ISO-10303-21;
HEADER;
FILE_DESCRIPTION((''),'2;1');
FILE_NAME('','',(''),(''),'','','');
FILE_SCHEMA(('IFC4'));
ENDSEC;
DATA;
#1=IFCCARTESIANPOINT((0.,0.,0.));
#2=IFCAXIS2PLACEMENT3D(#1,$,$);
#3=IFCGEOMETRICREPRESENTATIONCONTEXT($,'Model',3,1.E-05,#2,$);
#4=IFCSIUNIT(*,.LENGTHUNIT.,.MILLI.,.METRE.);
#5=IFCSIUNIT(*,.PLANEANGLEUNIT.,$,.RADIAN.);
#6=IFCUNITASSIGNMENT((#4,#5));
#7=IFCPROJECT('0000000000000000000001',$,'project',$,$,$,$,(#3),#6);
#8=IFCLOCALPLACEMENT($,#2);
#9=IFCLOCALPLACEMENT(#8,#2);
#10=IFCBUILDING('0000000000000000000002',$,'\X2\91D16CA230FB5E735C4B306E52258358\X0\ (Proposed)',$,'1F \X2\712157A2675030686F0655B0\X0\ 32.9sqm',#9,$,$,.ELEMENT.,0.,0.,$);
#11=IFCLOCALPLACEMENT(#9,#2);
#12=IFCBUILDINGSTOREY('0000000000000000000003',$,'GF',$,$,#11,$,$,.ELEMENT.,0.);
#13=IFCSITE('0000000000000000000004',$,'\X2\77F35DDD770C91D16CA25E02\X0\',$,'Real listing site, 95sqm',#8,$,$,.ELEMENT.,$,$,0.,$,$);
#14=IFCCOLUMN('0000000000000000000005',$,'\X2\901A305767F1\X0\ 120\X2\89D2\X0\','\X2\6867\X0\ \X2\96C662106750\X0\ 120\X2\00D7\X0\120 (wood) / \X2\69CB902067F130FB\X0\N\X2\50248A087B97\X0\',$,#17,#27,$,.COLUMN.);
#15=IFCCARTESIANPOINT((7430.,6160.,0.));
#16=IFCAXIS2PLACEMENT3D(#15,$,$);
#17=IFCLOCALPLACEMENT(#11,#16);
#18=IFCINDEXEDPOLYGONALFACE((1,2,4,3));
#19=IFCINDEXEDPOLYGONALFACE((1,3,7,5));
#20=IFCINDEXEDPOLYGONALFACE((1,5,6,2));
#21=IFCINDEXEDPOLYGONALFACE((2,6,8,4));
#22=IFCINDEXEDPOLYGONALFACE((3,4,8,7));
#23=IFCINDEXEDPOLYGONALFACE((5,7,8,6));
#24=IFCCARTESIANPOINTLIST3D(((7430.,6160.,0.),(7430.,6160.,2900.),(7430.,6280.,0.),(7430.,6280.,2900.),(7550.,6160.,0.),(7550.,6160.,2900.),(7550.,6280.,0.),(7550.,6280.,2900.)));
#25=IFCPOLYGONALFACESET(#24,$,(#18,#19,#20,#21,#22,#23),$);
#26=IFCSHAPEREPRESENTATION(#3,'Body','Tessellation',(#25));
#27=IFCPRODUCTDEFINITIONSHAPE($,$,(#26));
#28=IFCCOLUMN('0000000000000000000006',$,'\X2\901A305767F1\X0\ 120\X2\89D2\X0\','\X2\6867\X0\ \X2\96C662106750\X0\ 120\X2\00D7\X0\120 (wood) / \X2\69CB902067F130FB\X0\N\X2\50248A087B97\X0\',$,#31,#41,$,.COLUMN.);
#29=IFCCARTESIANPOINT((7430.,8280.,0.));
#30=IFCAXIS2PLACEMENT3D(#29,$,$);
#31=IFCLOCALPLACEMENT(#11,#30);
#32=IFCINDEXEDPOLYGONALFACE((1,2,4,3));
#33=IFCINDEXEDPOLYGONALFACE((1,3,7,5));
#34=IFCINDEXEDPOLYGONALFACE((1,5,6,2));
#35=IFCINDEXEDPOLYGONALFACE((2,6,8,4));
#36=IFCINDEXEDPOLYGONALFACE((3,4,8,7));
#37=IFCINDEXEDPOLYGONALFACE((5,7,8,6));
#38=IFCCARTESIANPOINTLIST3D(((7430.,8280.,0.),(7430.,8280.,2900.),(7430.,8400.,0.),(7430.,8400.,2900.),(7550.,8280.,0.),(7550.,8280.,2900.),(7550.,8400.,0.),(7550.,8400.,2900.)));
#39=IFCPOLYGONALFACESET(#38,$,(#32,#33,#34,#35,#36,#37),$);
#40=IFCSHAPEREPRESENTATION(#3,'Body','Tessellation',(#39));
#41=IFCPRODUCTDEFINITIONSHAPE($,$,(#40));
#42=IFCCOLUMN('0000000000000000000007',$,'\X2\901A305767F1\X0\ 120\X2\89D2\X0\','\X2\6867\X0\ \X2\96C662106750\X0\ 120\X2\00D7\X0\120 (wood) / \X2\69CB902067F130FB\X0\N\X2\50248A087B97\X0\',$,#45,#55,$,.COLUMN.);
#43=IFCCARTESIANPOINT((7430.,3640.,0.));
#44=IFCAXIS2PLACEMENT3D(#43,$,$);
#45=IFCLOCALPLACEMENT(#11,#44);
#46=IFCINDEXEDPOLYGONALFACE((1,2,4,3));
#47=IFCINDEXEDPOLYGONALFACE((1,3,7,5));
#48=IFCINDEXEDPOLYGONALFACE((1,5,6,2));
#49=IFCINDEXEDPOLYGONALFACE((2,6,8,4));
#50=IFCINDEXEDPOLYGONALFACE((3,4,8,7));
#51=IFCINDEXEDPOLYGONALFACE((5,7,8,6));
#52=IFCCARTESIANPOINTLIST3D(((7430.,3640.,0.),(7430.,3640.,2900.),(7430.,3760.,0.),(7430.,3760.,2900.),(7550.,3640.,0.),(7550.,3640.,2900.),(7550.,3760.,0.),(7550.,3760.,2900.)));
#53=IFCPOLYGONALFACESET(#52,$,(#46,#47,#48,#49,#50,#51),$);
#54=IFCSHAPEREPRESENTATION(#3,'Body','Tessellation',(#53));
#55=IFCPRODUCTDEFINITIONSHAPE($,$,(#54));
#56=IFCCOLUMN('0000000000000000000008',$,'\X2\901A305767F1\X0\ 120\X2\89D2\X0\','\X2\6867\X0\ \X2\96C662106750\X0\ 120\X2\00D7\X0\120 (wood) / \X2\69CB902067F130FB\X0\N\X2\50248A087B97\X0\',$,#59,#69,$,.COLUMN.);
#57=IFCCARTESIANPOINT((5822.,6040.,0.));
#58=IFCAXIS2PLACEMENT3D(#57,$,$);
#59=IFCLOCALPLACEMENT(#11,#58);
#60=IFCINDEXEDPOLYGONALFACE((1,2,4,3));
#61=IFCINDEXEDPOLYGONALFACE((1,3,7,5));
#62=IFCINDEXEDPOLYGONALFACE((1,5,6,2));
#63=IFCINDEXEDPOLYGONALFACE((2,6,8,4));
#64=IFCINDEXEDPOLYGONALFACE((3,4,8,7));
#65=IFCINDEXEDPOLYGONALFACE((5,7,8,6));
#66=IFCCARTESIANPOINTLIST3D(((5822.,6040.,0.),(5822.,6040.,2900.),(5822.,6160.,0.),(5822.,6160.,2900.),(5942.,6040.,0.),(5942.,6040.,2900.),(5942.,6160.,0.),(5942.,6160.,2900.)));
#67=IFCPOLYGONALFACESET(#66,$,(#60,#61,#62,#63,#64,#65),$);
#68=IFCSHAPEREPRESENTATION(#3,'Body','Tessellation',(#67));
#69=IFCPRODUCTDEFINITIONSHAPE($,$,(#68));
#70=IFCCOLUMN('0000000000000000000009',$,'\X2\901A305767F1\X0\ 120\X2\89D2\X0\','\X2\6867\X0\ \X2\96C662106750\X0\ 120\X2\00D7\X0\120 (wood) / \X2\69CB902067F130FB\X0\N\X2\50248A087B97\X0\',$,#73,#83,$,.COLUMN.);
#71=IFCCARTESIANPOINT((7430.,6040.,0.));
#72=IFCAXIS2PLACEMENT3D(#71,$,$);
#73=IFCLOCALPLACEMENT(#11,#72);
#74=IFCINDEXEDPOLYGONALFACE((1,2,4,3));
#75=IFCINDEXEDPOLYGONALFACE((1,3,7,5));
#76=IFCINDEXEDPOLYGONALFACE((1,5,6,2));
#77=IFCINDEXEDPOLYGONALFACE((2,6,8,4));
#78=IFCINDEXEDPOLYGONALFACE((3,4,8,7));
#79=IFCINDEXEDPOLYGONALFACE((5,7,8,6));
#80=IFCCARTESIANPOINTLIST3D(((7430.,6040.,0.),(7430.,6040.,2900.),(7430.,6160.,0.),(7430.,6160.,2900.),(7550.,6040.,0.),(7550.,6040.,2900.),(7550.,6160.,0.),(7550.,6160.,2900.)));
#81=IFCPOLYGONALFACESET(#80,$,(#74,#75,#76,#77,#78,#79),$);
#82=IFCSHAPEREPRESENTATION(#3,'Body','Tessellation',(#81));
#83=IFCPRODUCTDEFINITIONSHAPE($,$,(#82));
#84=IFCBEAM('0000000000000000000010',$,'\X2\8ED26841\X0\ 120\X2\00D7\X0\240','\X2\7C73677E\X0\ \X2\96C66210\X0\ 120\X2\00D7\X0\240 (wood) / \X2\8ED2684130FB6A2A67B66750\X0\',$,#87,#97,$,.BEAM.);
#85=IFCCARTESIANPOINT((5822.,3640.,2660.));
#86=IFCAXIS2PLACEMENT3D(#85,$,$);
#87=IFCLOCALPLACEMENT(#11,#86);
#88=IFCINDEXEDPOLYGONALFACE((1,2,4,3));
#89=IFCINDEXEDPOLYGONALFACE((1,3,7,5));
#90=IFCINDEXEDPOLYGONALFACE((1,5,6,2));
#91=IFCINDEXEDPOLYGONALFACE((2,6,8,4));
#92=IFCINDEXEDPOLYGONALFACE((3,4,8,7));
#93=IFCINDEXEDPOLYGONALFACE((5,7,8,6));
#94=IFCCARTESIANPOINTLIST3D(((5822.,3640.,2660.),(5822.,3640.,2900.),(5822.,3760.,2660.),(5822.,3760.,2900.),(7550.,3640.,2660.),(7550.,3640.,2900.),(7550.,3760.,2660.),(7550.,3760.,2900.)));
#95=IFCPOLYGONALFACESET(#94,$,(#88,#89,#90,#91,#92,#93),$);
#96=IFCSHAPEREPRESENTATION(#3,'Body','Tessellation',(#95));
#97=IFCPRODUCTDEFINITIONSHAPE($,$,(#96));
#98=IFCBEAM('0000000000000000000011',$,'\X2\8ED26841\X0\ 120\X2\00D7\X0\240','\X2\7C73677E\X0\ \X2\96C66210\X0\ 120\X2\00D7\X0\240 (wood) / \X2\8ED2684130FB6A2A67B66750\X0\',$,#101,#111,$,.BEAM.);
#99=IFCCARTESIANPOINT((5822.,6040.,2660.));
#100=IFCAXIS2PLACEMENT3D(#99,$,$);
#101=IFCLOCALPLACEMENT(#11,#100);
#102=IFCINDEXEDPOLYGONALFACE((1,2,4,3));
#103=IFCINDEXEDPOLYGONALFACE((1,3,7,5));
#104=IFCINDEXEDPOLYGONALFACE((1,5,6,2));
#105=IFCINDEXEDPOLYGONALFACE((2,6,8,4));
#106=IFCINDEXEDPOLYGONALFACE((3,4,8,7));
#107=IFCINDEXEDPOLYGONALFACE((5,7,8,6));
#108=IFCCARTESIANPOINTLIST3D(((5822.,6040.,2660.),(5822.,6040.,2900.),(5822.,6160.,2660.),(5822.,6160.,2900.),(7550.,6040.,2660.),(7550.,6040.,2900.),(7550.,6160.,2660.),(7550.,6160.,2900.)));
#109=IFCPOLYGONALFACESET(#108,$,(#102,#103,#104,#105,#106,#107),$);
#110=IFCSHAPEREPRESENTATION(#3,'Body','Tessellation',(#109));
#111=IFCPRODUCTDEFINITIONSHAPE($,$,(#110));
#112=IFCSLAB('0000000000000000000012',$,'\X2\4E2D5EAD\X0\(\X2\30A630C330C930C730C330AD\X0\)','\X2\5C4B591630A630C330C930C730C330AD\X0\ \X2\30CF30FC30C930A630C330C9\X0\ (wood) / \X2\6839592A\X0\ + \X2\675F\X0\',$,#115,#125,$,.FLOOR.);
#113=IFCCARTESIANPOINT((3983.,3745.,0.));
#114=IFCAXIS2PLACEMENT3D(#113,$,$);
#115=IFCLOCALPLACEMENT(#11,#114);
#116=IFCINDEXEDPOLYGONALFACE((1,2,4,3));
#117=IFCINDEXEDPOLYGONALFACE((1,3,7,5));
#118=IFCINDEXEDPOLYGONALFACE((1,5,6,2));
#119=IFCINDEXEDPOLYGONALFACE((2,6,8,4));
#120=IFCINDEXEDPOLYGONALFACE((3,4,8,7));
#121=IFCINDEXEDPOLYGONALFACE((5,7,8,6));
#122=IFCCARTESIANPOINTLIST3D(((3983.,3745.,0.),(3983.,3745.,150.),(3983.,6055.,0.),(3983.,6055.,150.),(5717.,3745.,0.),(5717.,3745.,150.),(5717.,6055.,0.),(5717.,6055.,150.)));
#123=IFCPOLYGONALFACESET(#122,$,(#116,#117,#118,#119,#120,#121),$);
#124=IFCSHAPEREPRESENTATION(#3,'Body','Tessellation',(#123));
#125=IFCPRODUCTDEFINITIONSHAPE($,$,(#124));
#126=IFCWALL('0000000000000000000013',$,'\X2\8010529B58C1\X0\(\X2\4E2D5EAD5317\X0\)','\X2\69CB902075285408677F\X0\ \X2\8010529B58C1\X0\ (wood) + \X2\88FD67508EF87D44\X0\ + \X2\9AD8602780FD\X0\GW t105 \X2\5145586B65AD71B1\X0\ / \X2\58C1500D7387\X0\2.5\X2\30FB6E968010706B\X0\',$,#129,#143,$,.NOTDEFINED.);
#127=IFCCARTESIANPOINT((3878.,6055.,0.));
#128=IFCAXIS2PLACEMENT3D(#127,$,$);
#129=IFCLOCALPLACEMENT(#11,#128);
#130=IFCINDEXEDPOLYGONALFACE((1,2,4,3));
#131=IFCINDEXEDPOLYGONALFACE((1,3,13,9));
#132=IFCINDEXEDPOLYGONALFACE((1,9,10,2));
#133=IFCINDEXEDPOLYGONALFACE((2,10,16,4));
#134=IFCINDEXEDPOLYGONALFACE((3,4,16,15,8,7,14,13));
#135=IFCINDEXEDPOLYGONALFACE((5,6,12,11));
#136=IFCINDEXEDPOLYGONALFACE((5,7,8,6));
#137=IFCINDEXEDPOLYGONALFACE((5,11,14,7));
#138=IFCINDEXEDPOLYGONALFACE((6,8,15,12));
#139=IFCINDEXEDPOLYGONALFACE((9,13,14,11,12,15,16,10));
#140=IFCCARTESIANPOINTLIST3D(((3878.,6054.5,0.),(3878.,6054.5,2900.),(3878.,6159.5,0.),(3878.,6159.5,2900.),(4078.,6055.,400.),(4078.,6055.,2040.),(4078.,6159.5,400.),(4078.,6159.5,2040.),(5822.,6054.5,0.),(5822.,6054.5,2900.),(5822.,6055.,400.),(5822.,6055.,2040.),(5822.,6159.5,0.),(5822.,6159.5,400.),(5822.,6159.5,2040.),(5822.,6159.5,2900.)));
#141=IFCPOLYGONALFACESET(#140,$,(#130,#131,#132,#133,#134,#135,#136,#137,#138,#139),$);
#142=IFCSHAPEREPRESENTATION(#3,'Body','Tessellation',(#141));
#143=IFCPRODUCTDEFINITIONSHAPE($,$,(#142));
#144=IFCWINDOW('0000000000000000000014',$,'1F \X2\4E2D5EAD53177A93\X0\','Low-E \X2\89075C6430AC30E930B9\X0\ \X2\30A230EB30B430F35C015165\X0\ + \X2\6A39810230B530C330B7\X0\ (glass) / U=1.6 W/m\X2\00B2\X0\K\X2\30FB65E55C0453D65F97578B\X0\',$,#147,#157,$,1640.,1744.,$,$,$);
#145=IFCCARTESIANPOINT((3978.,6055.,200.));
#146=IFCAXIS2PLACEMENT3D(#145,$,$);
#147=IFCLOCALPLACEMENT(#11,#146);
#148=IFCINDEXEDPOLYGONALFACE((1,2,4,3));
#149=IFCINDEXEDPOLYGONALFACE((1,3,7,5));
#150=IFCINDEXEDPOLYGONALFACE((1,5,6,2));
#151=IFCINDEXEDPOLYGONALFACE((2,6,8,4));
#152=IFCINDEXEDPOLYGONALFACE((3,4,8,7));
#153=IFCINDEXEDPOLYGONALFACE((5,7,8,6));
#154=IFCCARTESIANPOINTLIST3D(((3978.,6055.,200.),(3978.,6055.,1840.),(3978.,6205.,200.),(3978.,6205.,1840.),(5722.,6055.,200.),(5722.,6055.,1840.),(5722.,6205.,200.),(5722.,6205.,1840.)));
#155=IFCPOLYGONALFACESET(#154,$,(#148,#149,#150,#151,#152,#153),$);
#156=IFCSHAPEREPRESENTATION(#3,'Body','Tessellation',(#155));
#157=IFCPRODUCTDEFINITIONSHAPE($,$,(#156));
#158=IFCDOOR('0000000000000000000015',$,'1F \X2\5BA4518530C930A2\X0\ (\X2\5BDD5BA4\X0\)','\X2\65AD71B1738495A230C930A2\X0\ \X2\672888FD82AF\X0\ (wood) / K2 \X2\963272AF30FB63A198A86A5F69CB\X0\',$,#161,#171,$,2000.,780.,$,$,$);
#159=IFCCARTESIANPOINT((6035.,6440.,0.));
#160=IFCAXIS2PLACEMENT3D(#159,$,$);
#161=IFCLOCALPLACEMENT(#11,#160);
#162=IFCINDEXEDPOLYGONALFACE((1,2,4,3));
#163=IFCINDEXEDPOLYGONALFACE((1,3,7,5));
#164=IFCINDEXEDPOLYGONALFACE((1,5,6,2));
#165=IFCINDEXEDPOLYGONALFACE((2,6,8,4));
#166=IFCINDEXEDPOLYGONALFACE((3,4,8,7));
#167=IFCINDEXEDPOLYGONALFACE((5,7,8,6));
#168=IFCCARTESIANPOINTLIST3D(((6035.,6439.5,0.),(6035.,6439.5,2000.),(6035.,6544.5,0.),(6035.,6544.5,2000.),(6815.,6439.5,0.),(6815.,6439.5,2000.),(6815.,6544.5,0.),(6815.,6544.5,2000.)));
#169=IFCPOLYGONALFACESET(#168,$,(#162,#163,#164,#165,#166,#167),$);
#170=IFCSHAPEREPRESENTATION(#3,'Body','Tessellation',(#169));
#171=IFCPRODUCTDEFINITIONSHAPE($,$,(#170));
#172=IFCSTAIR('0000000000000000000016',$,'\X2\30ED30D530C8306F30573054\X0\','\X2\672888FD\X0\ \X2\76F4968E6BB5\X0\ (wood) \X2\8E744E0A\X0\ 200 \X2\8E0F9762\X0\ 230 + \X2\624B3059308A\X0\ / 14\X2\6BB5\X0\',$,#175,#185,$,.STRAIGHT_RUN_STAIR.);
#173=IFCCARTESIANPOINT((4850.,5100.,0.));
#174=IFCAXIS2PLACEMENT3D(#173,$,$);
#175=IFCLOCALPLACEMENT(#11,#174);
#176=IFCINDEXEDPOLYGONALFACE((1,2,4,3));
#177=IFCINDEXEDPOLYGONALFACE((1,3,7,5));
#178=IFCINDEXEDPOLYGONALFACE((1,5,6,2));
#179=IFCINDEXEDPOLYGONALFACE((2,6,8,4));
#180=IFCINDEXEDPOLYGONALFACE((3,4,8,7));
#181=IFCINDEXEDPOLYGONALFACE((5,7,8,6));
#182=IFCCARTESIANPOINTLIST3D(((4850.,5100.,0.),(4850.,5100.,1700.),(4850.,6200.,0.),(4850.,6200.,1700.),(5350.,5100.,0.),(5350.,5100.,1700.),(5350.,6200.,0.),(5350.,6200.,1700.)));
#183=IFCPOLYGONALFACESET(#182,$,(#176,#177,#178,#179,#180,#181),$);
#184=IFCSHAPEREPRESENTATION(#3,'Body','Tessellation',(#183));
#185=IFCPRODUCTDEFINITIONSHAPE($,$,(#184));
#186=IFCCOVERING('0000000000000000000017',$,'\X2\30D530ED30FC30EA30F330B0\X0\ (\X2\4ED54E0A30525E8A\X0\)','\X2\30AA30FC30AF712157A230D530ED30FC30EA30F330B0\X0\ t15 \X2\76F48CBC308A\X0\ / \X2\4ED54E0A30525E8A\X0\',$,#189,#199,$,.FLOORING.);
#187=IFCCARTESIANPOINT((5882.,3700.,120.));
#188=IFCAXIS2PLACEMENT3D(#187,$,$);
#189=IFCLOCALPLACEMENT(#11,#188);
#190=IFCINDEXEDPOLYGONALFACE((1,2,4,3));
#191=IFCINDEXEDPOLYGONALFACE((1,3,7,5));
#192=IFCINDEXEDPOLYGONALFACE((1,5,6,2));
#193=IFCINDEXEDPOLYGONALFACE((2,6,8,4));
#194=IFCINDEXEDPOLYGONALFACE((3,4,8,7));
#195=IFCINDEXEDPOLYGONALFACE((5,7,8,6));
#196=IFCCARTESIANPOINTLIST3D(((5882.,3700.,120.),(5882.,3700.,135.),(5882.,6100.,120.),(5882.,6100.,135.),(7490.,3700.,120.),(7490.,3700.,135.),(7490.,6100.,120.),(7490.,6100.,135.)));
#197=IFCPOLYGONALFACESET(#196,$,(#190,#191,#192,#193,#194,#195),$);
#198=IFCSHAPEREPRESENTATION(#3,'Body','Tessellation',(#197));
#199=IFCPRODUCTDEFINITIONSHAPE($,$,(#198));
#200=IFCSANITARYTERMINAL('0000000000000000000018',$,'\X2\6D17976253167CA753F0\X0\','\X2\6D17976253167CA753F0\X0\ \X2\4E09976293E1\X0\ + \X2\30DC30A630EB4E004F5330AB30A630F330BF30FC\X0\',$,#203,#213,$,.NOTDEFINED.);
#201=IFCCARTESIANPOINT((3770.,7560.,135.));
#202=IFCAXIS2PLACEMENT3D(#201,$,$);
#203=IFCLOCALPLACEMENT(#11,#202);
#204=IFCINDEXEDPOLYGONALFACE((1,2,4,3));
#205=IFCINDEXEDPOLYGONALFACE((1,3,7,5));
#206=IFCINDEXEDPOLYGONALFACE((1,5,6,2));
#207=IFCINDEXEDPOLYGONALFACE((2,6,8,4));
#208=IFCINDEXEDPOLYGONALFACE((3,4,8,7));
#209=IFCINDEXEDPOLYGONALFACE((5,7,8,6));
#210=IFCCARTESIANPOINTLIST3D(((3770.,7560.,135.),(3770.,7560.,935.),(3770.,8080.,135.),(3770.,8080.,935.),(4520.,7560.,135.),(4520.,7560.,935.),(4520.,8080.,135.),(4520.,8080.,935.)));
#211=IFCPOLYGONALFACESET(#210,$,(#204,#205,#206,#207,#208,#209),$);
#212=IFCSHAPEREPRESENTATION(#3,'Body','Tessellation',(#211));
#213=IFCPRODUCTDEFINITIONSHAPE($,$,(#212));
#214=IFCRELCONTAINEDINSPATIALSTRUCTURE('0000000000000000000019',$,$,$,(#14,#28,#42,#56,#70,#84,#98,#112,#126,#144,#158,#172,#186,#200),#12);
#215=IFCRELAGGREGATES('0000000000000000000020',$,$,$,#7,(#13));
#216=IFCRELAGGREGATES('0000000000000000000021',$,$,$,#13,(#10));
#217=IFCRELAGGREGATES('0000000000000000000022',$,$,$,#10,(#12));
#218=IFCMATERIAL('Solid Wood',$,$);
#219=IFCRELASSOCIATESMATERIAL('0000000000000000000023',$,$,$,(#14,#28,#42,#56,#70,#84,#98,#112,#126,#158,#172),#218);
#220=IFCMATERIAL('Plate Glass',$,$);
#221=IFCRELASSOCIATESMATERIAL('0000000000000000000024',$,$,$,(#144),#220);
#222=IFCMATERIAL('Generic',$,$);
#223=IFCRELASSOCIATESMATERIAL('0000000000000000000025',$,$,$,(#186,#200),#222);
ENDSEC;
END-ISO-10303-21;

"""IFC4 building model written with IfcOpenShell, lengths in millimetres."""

from ifc_helpers import new_model, si_unit, frame, frame_2d, origin, place, context, project, spatial, rectangle, extrude, material, element, fill, save


model = new_model("IFC4")

# Units and contexts
model_context = context("Model", 3, precision=1e-05, world=origin())
ifc_project = project(units=[si_unit("LENGTHUNIT", "METRE", prefix="MILLI"), si_unit("PLANEANGLEUNIT", "RADIAN")], contexts=[model_context])

# Site, building, storey
site_placement = place(None, origin())
site = spatial("IfcSite", under=ifc_project, at=site_placement, Name="石川県金沢市", ObjectType="Real listing site, 95sqm", CompositionType="ELEMENT", RefElevation=0.0)
building_placement = place(site_placement, origin())
building = spatial("IfcBuilding", under=site, at=building_placement, Name="金沢・平屋の別荘 (Proposed)", ObjectType="1F 無垢材と漆喰 32.9sqm", CompositionType="ELEMENT", ElevationOfRefHeight=0.0, ElevationOfTerrain=0.0)
storey_placement = place(building_placement, origin())
storey = spatial("IfcBuildingStorey", under=building, at=storey_placement, Name="GF", CompositionType="ELEMENT", Elevation=0.0)

# Columns
ifc_material_1 = material(Name="Solid Wood")
column_1_placement = place(storey_placement, frame((7430.0, 6160.0, 0.0)))
element("IfcColumn", 1, at=column_1_placement, inside=storey, material=ifc_material_1, Name="通し柱 120角", Description="桧 集成材 120×120 (wood) / 構造柱・N値計算", PredefinedType="COLUMN", context=model_context, shape_type="SweptSolid", body=[
    extrude(rectangle(XDim=120.0, YDim=120.0, at=frame_2d((60.0, 60.0))), frame((7430.0, 6160.0, 0.0)), (0.0, 0.0, 1.0), 2900.0),
])
column_2_placement = place(storey_placement, frame((7430.0, 8280.0, 0.0)))
element("IfcColumn", 2, at=column_2_placement, inside=storey, material=ifc_material_1, Name="通し柱 120角", Description="桧 集成材 120×120 (wood) / 構造柱・N値計算", PredefinedType="COLUMN", context=model_context, shape_type="SweptSolid", body=[
    extrude(rectangle(XDim=120.0, YDim=120.0, at=frame_2d((60.0, 60.0))), frame((7430.0, 8280.0, 0.0)), (0.0, 0.0, 1.0), 2900.0),
])
column_3_placement = place(storey_placement, frame((7430.0, 3640.0, 0.0)))
element("IfcColumn", 3, at=column_3_placement, inside=storey, material=ifc_material_1, Name="通し柱 120角", Description="桧 集成材 120×120 (wood) / 構造柱・N値計算", PredefinedType="COLUMN", context=model_context, shape_type="SweptSolid", body=[
    extrude(rectangle(XDim=120.0, YDim=120.0, at=frame_2d((60.0, 60.0))), frame((7430.0, 3640.0, 0.0)), (0.0, 0.0, 1.0), 2900.0),
])
column_4_placement = place(storey_placement, frame((5822.0, 6040.0, 0.0)))
element("IfcColumn", 4, at=column_4_placement, inside=storey, material=ifc_material_1, Name="通し柱 120角", Description="桧 集成材 120×120 (wood) / 構造柱・N値計算", PredefinedType="COLUMN", context=model_context, shape_type="SweptSolid", body=[
    extrude(rectangle(XDim=120.0, YDim=120.0, at=frame_2d((60.0, 60.0))), frame((5822.0, 6040.0, 0.0)), (0.0, 0.0, 1.0), 2900.0),
])
column_5_placement = place(storey_placement, frame((7430.0, 6040.0, 0.0)))
element("IfcColumn", 5, at=column_5_placement, inside=storey, material=ifc_material_1, Name="通し柱 120角", Description="桧 集成材 120×120 (wood) / 構造柱・N値計算", PredefinedType="COLUMN", context=model_context, shape_type="SweptSolid", body=[
    extrude(rectangle(XDim=120.0, YDim=120.0, at=frame_2d((60.0, 60.0))), frame((7430.0, 6040.0, 0.0)), (0.0, 0.0, 1.0), 2900.0),
])

# Beams
beam_1_placement = place(storey_placement, frame((5822.0, 3640.0, 2660.0)))
element("IfcBeam", 6, at=beam_1_placement, inside=storey, material=ifc_material_1, Name="軒桁 120×240", Description="米松 集成 120×240 (wood) / 軒桁・横架材", PredefinedType="BEAM", context=model_context, shape_type="SweptSolid", body=[
    extrude(rectangle(XDim=1728.0, YDim=120.0, at=frame_2d((864.0, 60.0))), frame((5822.0, 3640.0, 2660.0)), (0.0, 0.0, 1.0), 240.0),
])
beam_2_placement = place(storey_placement, frame((5822.0, 6040.0, 2660.0)))
element("IfcBeam", 7, at=beam_2_placement, inside=storey, material=ifc_material_1, Name="軒桁 120×240", Description="米松 集成 120×240 (wood) / 軒桁・横架材", PredefinedType="BEAM", context=model_context, shape_type="SweptSolid", body=[
    extrude(rectangle(XDim=1728.0, YDim=120.0, at=frame_2d((864.0, 60.0))), frame((5822.0, 6040.0, 2660.0)), (0.0, 0.0, 1.0), 240.0),
])

# Slab
slab_placement = place(storey_placement, frame((3983.0, 3745.0, 0.0)))
element("IfcSlab", 8, at=slab_placement, inside=storey, material=ifc_material_1, Name="中庭(ウッドデッキ)", Description="屋外ウッドデッキ ハードウッド (wood) / 根太 + 束", PredefinedType="FLOOR", context=model_context, shape_type="SweptSolid", body=[
    extrude(rectangle(XDim=1734.0, YDim=2310.0, at=frame_2d((867.0, 1155.0))), frame((3983.0, 3745.0, 0.0)), (0.0, 0.0, 1.0), 150.0),
])

# Wall, opening, window
wall_1_placement = place(storey_placement, frame((3878.0, 6055.0, 0.0)))
wall_1 = element("IfcWall", 9, at=wall_1_placement, inside=storey, material=ifc_material_1, Name="耐力壁(中庭北)", Description="構造用合板 耐力壁 (wood) + 製材軸組 + 高性能GW t105 充填断熱 / 壁倍率2.5・準耐火", PredefinedType="NOTDEFINED", context=model_context, shape_type="SweptSolid", body=[
    extrude(rectangle(XDim=1944.0, YDim=105.0, at=frame_2d((972.0, 52.0))), frame((3878.0, 6055.0, 0.0)), (0.0, 0.0, 1.0), 2900.0),
])
opening_placement = place(storey_placement, frame((3978.0, 6055.0, 200.0)))
opening = element("IfcOpeningElement", 10, at=opening_placement, cuts=wall_1, PredefinedType="NOTDEFINED", context=model_context, shape_type="SweptSolid", body=[
    extrude(rectangle(XDim=1744.0, YDim=150.0, at=frame_2d((872.0, 75.0))), frame((3978.0, 6055.0, 200.0)), (0.0, 0.0, 1.0), 1640.0),
])
ifc_material_2 = material(Name="Plate Glass")
window_placement = place(storey_placement, frame((3978.0, 6055.0, 200.0)))
window = element("IfcWindow", 11, at=window_placement, inside=storey, material=ifc_material_2, Name="1F 中庭北窓", Description="Low-E 複層ガラス アルゴン封入 + 樹脂サッシ (glass) / U=1.6 W/m²K・日射取得型", OverallHeight=1640.0, OverallWidth=1744.0, context=model_context, shape_type="SweptSolid", body=[
    extrude(rectangle(XDim=1744.0, YDim=150.0, at=frame_2d((872.0, 75.0))), frame((3978.0, 6055.0, 200.0)), (0.0, 0.0, 1.0), 1640.0),
])
fill(opening, window)

# Door
door_placement = place(storey_placement, frame((6035.0, 6440.0, 0.0)))
element("IfcDoor", 12, at=door_placement, inside=storey, material=ifc_material_1, Name="1F 室内ドア (寝室)", Description="断熱玄関ドア 木製芯 (wood) / K2 防犯・採風機構", OverallHeight=2000.0, OverallWidth=780.0, context=model_context, shape_type="SweptSolid", body=[
    extrude(rectangle(XDim=780.0, YDim=105.0, at=frame_2d((390.0, 52.0))), frame((6035.0, 6440.0, 0.0)), (0.0, 0.0, 1.0), 2000.0),
])

# Stair
stair_placement = place(storey_placement, frame((4850.0, 5100.0, 0.0)))
element("IfcStair", 13, at=stair_placement, inside=storey, material=ifc_material_1, Name="ロフトはしご", Description="木製 直階段 (wood) 蹴上 200 踏面 230 + 手すり / 14段", PredefinedType="STRAIGHT_RUN_STAIR", context=model_context, shape_type="SweptSolid", body=[
    extrude(rectangle(XDim=500.0, YDim=1100.0, at=frame_2d((250.0, 550.0))), frame((4850.0, 5100.0, 0.0)), (0.0, 0.0, 1.0), 1700.0),
])

# Covering
ifc_material_3 = material(Name="Generic")
covering_placement = place(storey_placement, frame((5882.0, 3700.0, 120.0)))
element("IfcCovering", 14, at=covering_placement, inside=storey, material=ifc_material_3, Name="フローリング (仕上げ床)", Description="オーク無垢フローリング t15 直貼り / 仕上げ床", PredefinedType="FLOORING", context=model_context, shape_type="SweptSolid", body=[
    extrude(rectangle(XDim=1608.0, YDim=2400.0, at=frame_2d((804.0, 1200.0))), frame((5882.0, 3700.0, 120.0)), (0.0, 0.0, 1.0), 15.0),
])

# Sanitary terminal
sanitary_terminal_1_placement = place(storey_placement, frame((3770.0, 7560.0, 135.0)))
element("IfcSanitaryTerminal", 15, at=sanitary_terminal_1_placement, inside=storey, material=ifc_material_3, Name="洗面化粧台", Description="洗面化粧台 三面鏡 + ボウル一体カウンター", PredefinedType="NOTDEFINED", context=model_context, shape_type="SweptSolid", body=[
    extrude(rectangle(XDim=750.0, YDim=520.0, at=frame_2d((375.0, 260.0))), frame((3770.0, 7560.0, 135.0)), (0.0, 0.0, 1.0), 800.0),
])

save(model, "model.ifc")
